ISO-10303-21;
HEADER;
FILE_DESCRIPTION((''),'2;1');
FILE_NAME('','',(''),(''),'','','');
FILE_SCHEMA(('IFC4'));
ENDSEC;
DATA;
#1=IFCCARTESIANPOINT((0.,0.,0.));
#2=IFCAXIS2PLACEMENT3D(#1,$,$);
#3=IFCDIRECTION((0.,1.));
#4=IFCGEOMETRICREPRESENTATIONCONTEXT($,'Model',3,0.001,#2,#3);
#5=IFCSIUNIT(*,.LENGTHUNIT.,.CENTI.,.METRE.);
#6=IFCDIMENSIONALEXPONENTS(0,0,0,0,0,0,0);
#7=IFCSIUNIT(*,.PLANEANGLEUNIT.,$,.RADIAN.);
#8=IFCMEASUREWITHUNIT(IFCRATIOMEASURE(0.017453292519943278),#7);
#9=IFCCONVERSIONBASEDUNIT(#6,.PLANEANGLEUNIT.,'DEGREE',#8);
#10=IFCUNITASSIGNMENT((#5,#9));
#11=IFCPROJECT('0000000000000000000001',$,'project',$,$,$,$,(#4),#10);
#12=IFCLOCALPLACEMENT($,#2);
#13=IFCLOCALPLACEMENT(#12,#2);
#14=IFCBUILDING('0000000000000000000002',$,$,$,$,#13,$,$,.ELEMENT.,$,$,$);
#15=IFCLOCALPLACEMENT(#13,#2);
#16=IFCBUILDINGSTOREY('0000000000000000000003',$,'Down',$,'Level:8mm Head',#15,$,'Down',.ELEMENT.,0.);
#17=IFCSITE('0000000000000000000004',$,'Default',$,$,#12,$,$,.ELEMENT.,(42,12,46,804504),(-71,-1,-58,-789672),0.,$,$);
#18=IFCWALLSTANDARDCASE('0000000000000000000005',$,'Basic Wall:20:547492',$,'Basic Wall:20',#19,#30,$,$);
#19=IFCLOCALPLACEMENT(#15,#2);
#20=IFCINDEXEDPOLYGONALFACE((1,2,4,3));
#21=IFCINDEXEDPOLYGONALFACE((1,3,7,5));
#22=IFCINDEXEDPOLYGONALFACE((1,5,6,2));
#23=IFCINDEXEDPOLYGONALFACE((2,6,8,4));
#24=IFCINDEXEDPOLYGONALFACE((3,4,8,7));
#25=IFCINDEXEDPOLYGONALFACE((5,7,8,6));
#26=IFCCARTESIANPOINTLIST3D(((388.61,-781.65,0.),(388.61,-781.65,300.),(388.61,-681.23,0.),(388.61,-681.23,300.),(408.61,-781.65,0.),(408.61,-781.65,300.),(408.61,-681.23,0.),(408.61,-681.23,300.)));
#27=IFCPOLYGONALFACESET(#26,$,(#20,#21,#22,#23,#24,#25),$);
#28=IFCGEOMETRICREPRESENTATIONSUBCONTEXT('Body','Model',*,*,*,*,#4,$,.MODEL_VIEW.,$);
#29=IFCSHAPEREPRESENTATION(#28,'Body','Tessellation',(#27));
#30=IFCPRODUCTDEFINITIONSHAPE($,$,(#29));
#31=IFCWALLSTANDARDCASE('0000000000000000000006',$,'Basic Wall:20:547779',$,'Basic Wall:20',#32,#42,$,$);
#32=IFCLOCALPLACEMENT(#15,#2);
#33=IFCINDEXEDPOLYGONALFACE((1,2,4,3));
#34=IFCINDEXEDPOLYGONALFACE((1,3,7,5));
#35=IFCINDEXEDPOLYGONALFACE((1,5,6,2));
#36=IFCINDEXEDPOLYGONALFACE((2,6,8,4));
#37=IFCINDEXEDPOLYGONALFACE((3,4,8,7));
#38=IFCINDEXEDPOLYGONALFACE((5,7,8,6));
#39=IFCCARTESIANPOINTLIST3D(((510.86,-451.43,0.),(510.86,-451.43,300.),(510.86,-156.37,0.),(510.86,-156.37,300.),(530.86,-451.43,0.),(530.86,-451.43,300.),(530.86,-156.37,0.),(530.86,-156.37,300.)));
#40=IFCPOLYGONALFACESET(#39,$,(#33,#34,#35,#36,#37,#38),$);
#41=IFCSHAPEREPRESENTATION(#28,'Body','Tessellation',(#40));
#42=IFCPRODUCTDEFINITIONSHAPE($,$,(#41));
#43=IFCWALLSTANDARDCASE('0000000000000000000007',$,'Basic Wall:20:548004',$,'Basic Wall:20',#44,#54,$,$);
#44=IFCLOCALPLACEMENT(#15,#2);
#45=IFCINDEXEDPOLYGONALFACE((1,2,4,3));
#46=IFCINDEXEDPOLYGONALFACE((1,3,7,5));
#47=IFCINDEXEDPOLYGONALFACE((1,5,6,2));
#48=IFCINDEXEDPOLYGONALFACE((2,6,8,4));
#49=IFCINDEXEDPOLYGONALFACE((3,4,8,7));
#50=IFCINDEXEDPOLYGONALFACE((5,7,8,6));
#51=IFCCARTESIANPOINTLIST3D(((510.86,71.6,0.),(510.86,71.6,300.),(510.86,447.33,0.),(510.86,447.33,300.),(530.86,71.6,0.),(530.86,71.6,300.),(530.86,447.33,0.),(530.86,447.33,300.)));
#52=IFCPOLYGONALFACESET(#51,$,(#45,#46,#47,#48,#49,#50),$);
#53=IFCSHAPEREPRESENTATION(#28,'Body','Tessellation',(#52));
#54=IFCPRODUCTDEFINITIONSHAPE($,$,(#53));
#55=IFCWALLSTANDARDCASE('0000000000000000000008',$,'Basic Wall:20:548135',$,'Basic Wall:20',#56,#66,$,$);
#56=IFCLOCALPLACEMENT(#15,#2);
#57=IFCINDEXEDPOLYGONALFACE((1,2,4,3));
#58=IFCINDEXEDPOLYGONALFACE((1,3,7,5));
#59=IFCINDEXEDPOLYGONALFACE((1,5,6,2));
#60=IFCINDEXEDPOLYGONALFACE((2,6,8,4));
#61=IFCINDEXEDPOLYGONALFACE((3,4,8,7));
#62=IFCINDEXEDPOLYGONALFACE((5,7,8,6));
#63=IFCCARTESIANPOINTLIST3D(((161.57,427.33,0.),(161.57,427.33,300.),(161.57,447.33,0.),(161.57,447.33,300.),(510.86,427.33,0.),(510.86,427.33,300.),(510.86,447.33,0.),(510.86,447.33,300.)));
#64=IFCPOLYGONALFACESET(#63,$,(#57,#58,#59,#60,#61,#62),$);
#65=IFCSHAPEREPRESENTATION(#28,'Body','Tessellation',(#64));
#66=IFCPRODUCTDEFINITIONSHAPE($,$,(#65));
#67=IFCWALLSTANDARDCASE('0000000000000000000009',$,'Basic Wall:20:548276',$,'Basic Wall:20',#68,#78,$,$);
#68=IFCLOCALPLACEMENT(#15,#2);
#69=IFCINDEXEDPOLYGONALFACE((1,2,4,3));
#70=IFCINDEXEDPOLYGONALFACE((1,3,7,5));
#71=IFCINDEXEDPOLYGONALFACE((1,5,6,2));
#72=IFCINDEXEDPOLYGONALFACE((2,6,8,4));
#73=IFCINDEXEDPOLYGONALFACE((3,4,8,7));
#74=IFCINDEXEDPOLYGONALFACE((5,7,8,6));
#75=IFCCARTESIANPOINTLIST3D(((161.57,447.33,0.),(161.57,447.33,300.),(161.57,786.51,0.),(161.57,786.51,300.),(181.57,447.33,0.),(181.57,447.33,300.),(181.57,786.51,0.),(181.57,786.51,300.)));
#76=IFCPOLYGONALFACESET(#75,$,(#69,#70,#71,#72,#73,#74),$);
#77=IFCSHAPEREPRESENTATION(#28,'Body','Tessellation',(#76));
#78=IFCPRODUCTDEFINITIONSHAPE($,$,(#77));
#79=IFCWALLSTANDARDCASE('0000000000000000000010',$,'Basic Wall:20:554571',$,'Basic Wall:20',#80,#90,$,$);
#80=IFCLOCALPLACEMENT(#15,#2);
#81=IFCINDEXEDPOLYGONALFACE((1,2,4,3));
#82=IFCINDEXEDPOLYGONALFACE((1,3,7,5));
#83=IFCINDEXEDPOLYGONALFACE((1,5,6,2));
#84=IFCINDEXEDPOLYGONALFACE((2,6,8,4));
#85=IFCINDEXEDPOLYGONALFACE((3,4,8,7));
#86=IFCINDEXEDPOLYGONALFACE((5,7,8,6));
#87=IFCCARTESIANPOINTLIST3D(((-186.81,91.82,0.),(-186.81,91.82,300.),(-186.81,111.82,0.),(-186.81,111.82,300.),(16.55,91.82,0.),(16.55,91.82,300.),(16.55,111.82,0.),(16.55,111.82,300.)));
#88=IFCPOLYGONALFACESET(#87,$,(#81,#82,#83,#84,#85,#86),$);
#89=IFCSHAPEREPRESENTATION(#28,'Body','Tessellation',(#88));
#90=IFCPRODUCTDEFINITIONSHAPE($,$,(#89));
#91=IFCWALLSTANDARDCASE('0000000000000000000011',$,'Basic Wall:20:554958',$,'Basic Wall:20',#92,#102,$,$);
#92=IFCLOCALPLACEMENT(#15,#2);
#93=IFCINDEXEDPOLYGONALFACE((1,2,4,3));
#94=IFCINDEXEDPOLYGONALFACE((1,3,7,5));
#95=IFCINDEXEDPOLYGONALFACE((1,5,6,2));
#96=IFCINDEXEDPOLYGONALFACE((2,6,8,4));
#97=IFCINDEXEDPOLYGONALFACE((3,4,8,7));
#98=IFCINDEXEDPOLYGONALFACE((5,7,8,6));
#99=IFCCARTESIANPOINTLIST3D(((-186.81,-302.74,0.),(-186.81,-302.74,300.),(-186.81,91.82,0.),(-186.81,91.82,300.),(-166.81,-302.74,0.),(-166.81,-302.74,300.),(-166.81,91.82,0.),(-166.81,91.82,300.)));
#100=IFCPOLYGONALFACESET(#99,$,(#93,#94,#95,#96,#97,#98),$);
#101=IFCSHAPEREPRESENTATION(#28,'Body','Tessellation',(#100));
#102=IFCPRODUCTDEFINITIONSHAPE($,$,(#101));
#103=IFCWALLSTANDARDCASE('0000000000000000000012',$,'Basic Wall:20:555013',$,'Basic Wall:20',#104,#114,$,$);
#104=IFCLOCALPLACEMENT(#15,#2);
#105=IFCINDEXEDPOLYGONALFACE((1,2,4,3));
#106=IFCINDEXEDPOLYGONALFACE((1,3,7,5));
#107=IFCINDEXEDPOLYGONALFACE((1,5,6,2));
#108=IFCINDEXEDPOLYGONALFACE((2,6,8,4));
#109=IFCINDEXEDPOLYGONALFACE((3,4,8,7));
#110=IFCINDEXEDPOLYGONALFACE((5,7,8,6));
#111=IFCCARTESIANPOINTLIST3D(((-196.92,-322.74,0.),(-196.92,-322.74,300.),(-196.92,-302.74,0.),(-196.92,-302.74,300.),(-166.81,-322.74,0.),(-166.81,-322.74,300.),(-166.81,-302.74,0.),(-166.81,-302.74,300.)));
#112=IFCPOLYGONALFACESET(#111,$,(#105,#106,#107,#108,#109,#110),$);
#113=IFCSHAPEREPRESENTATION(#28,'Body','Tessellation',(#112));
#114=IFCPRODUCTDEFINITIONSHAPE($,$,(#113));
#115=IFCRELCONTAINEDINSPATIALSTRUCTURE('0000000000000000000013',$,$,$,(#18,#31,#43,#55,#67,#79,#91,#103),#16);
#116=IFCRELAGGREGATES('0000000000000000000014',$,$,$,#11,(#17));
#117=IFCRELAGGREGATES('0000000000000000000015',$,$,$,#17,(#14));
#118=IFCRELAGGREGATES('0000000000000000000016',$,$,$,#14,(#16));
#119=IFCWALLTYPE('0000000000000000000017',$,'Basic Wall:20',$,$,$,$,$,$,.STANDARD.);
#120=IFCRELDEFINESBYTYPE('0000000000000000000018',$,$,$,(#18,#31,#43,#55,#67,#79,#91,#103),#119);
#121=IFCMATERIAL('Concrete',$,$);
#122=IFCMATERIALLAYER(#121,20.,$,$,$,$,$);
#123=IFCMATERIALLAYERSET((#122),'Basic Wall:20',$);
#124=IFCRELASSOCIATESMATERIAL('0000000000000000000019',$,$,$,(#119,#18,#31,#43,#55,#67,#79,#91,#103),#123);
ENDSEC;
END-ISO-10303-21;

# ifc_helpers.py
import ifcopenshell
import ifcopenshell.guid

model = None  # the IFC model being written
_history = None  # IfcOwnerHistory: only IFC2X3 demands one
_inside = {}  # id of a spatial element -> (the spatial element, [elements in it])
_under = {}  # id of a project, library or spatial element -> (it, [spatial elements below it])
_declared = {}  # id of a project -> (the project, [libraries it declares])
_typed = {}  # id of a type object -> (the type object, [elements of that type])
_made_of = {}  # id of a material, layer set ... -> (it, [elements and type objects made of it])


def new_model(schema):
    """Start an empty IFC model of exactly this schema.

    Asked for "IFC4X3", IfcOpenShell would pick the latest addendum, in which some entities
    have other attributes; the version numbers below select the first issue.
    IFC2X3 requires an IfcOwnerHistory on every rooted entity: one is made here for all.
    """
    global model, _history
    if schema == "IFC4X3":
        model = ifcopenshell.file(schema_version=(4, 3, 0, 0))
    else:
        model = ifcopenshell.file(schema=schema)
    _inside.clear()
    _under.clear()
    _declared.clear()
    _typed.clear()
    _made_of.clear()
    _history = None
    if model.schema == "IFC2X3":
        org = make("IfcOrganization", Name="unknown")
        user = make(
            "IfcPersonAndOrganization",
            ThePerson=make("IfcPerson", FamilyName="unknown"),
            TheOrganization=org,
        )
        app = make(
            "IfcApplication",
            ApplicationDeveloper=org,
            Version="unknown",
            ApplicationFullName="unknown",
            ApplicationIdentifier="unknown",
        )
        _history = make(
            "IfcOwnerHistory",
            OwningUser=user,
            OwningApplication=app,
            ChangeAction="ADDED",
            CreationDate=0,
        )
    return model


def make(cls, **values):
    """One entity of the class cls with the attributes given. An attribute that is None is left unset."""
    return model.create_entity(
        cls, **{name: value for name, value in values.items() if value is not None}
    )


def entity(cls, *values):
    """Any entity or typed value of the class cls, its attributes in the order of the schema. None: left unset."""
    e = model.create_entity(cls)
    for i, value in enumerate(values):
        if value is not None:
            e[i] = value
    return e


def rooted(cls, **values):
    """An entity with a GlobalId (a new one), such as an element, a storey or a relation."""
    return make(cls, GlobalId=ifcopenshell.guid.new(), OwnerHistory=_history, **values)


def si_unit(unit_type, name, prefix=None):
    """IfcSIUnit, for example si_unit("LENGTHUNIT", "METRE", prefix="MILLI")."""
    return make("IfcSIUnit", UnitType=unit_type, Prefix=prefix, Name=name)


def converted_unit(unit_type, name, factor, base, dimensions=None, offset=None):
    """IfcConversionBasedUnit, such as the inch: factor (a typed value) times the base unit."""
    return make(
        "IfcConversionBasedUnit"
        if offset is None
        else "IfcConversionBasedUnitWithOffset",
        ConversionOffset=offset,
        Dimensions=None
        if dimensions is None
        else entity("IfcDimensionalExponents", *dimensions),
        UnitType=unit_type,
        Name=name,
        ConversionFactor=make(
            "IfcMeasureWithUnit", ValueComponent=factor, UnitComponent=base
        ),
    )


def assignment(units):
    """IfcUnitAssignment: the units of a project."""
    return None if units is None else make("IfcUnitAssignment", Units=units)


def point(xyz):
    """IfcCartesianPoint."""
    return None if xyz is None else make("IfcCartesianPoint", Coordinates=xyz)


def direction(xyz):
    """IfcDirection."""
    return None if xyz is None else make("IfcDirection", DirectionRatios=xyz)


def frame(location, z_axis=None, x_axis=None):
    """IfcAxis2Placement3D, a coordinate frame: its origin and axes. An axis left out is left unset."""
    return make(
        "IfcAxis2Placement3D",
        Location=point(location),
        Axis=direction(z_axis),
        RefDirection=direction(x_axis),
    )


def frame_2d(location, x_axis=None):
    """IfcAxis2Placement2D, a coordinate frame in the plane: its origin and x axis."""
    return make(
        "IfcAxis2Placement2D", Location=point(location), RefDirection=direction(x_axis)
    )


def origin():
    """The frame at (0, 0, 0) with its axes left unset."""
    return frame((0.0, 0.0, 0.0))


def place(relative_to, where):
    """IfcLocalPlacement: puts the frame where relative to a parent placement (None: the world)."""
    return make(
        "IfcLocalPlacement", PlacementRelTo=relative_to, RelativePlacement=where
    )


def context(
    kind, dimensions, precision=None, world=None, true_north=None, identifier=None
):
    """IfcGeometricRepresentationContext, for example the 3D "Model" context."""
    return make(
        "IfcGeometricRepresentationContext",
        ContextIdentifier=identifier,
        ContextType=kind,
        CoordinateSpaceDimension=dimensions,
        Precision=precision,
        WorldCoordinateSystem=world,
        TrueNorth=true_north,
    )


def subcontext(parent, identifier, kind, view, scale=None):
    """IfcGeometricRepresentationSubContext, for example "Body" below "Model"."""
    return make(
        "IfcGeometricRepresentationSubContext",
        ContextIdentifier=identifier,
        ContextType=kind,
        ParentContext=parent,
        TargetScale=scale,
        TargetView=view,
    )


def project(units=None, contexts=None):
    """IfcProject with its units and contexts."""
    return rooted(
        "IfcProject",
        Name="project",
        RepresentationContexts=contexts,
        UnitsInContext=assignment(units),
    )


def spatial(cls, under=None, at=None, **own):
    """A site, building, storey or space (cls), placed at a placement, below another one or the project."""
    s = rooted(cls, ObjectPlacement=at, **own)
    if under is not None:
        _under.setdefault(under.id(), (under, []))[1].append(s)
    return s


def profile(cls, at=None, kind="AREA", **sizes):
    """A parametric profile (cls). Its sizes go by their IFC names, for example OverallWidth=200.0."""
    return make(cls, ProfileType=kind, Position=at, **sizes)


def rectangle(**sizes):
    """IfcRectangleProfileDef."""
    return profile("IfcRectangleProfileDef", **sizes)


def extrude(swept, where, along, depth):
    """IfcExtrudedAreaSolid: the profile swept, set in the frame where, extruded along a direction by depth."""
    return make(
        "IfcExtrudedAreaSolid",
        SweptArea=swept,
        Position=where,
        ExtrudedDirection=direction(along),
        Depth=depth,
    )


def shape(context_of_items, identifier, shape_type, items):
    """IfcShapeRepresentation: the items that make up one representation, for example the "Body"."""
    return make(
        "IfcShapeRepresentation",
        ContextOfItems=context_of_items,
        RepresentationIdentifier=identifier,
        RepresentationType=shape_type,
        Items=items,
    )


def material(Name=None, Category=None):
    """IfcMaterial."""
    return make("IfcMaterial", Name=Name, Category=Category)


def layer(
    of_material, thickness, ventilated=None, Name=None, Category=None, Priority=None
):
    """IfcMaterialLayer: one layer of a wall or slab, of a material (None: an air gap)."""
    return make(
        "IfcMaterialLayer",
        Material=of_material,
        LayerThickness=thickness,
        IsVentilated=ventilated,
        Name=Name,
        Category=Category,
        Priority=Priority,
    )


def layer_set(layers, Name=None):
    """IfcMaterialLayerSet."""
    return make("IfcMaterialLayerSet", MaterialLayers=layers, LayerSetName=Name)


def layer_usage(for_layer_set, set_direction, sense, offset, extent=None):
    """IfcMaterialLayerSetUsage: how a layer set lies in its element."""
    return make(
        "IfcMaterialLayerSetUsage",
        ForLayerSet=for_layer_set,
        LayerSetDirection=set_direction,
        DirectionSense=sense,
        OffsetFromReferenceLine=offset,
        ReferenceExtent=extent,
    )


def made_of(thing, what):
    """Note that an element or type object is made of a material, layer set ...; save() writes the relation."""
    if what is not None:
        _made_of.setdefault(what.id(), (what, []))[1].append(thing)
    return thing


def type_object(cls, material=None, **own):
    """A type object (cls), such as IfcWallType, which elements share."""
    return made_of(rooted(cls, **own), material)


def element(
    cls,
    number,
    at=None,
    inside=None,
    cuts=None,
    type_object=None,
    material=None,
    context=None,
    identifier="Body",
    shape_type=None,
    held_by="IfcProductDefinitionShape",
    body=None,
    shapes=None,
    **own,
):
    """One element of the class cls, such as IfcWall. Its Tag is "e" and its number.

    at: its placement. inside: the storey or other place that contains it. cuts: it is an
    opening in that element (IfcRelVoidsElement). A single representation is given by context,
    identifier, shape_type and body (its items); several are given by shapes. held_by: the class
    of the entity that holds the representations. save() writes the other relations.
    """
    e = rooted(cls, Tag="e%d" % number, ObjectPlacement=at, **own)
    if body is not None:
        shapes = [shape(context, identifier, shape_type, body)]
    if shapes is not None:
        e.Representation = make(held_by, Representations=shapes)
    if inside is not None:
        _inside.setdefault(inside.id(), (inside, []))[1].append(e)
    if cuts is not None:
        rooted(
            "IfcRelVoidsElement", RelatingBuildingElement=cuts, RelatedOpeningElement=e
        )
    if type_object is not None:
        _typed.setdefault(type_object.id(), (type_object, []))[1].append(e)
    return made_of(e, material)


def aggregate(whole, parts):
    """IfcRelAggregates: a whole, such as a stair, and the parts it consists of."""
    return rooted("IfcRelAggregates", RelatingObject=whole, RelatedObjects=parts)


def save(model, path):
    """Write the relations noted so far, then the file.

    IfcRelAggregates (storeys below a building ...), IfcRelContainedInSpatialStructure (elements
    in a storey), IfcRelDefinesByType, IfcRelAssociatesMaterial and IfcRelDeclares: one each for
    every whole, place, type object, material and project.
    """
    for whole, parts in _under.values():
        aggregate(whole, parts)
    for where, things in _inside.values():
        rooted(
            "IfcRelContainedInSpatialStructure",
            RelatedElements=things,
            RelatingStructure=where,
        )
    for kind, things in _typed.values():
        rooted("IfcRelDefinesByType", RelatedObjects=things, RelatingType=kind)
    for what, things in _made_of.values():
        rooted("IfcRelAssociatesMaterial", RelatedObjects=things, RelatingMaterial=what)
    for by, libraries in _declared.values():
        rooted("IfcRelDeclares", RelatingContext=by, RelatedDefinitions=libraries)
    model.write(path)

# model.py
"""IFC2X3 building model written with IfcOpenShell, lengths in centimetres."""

from ifc_helpers import new_model, entity, si_unit, converted_unit, direction, frame, frame_2d, origin, place, context, subcontext, project, spatial, rectangle, extrude, material, layer, layer_set, layer_usage, type_object, element, save


model = new_model("IFC2X3")

# Units and contexts
model_context = context("Model", 3, precision=0.001, world=origin(), true_north=direction((0.0, 1.0)))
body_context = subcontext(model_context, "Body", "Model", "MODEL_VIEW")
ifc_project = project(units=[si_unit("LENGTHUNIT", "METRE", prefix="CENTI"), converted_unit("PLANEANGLEUNIT", "DEGREE", entity("IfcRatioMeasure", 0.017453292519943278), si_unit("PLANEANGLEUNIT", "RADIAN"), dimensions=[0, 0, 0, 0, 0, 0, 0])], contexts=[model_context])

# Site, building, storey
site_placement = place(None, origin())
site = spatial("IfcSite", under=ifc_project, at=site_placement, Name="Default", CompositionType="ELEMENT", RefLatitude=(42, 12, 46, 804504), RefLongitude=(-71, -1, -58, -789672), RefElevation=0.0)
building_placement = place(site_placement, origin())
building = spatial("IfcBuilding", under=site, at=building_placement, CompositionType="ELEMENT")
storey_placement = place(building_placement, origin())
storey = spatial("IfcBuildingStorey", under=building, at=storey_placement, Name="Down", ObjectType="Level:8mm Head", LongName="Down", CompositionType="ELEMENT", Elevation=0.0)

# Shared definitions
ifc_material = material(Name="Concrete")

# Walls
ifc_layer_1 = layer(ifc_material, 20.0)
ifc_layer_set_1 = layer_set([ifc_layer_1], Name="Basic Wall:20")
wall_type_1 = type_object("IfcWallType", Name="Basic Wall:20", PredefinedType="STANDARD", material=ifc_layer_set_1)
ifc_layer_usage_1 = layer_usage(ifc_layer_set_1, "AXIS2", "POSITIVE", -10.0)
wall_1_placement = place(storey_placement, frame((398.61, -681.23, 0.0), z_axis=(0.0, 0.0, 1.0), x_axis=(0.0, -1.0, 0.0)))
element("IfcWallStandardCase", 1, at=wall_1_placement, inside=storey, type_object=wall_type_1, material=ifc_layer_usage_1, Name="Basic Wall:20:547492", ObjectType="Basic Wall:20", context=body_context, shape_type="SweptSolid", body=[
    extrude(rectangle(XDim=100.42, YDim=20.0, at=frame_2d((50.21, 0.0), x_axis=(-1.0, 0.0))), origin(), (0.0, 0.0, 1.0), 300.0),
])
ifc_layer_usage_2 = layer_usage(ifc_layer_set_1, "AXIS2", "NEGATIVE", 10.0)
wall_2_placement = place(storey_placement, frame((520.86, -451.43, 0.0), z_axis=(0.0, 0.0, 1.0), x_axis=(0.0, 1.0, 0.0)))
element("IfcWallStandardCase", 2, at=wall_2_placement, inside=storey, type_object=wall_type_1, material=ifc_layer_usage_2, Name="Basic Wall:20:547779", ObjectType="Basic Wall:20", context=body_context, shape_type="SweptSolid", body=[
    extrude(rectangle(XDim=295.06, YDim=20.0, at=frame_2d((147.53, 0.0), x_axis=(-1.0, 0.0))), origin(), (0.0, 0.0, 1.0), 300.0),
])
ifc_layer_usage_3 = layer_usage(ifc_layer_set_1, "AXIS2", "NEGATIVE", 10.0)
wall_3_placement = place(storey_placement, frame((520.86, 71.6, 0.0), z_axis=(0.0, 0.0, 1.0), x_axis=(0.0, 1.0, 0.0)))
element("IfcWallStandardCase", 3, at=wall_3_placement, inside=storey, type_object=wall_type_1, material=ifc_layer_usage_3, Name="Basic Wall:20:548004", ObjectType="Basic Wall:20", context=body_context, shape_type="SweptSolid", body=[
    extrude(rectangle(XDim=375.73, YDim=20.0, at=frame_2d((187.87, 0.0), x_axis=(-1.0, 0.0))), origin(), (0.0, 0.0, 1.0), 300.0),
])
ifc_layer_usage_4 = layer_usage(ifc_layer_set_1, "AXIS2", "NEGATIVE", 10.0)
wall_4_placement = place(storey_placement, frame((510.86, 437.33, 0.0), z_axis=(0.0, 0.0, 1.0), x_axis=(-1.0, 0.0, 0.0)))
element("IfcWallStandardCase", 4, at=wall_4_placement, inside=storey, type_object=wall_type_1, material=ifc_layer_usage_4, Name="Basic Wall:20:548135", ObjectType="Basic Wall:20", context=body_context, shape_type="SweptSolid", body=[
    extrude(rectangle(XDim=349.3, YDim=20.0, at=frame_2d((174.65, 0.0), x_axis=(-1.0, 0.0))), origin(), (0.0, 0.0, 1.0), 300.0),
])
ifc_layer_usage_5 = layer_usage(ifc_layer_set_1, "AXIS2", "NEGATIVE", 10.0)
wall_5_placement = place(storey_placement, frame((171.57, 447.33, 0.0), z_axis=(0.0, 0.0, 1.0), x_axis=(0.0, 1.0, 0.0)))
element("IfcWallStandardCase", 5, at=wall_5_placement, inside=storey, type_object=wall_type_1, material=ifc_layer_usage_5, Name="Basic Wall:20:548276", ObjectType="Basic Wall:20", context=body_context, shape_type="SweptSolid", body=[
    extrude(rectangle(XDim=339.19, YDim=20.0, at=frame_2d((169.59, 0.0), x_axis=(-1.0, 0.0))), origin(), (0.0, 0.0, 1.0), 300.0),
])
ifc_layer_usage_6 = layer_usage(ifc_layer_set_1, "AXIS2", "NEGATIVE", 10.0)
wall_6_placement = place(storey_placement, frame((16.55, 101.82, 0.0), z_axis=(0.0, 0.0, 1.0), x_axis=(-1.0, 0.0, 0.0)))
element("IfcWallStandardCase", 6, at=wall_6_placement, inside=storey, type_object=wall_type_1, material=ifc_layer_usage_6, Name="Basic Wall:20:554571", ObjectType="Basic Wall:20", context=body_context, shape_type="SweptSolid", body=[
    extrude(rectangle(XDim=203.37, YDim=20.0, at=frame_2d((101.68, 0.0), x_axis=(-1.0, 0.0))), origin(), (0.0, 0.0, 1.0), 300.0),
])
ifc_layer_usage_7 = layer_usage(ifc_layer_set_1, "AXIS2", "POSITIVE", -10.0)
wall_7_placement = place(storey_placement, frame((-176.81, 91.82, 0.0), z_axis=(0.0, 0.0, 1.0), x_axis=(0.0, -1.0, 0.0)))
element("IfcWallStandardCase", 7, at=wall_7_placement, inside=storey, type_object=wall_type_1, material=ifc_layer_usage_7, Name="Basic Wall:20:554958", ObjectType="Basic Wall:20", context=body_context, shape_type="SweptSolid", body=[
    extrude(rectangle(XDim=394.56, YDim=20.0, at=frame_2d((197.28, 0.0), x_axis=(-1.0, 0.0))), origin(), (0.0, 0.0, 1.0), 300.0),
])
ifc_layer_usage_8 = layer_usage(ifc_layer_set_1, "AXIS2", "NEGATIVE", 10.0)
wall_8_placement = place(storey_placement, frame((-166.81, -312.74, 0.0), z_axis=(0.0, 0.0, 1.0), x_axis=(-1.0, 0.0, 0.0)))
element("IfcWallStandardCase", 8, at=wall_8_placement, inside=storey, type_object=wall_type_1, material=ifc_layer_usage_8, Name="Basic Wall:20:555013", ObjectType="Basic Wall:20", context=body_context, shape_type="SweptSolid", body=[
    extrude(rectangle(XDim=30.11, YDim=20.0, at=frame_2d((15.06, 0.0), x_axis=(-1.0, 0.0))), origin(), (0.0, 0.0, 1.0), 300.0),
])

save(model, "model.ifc")
